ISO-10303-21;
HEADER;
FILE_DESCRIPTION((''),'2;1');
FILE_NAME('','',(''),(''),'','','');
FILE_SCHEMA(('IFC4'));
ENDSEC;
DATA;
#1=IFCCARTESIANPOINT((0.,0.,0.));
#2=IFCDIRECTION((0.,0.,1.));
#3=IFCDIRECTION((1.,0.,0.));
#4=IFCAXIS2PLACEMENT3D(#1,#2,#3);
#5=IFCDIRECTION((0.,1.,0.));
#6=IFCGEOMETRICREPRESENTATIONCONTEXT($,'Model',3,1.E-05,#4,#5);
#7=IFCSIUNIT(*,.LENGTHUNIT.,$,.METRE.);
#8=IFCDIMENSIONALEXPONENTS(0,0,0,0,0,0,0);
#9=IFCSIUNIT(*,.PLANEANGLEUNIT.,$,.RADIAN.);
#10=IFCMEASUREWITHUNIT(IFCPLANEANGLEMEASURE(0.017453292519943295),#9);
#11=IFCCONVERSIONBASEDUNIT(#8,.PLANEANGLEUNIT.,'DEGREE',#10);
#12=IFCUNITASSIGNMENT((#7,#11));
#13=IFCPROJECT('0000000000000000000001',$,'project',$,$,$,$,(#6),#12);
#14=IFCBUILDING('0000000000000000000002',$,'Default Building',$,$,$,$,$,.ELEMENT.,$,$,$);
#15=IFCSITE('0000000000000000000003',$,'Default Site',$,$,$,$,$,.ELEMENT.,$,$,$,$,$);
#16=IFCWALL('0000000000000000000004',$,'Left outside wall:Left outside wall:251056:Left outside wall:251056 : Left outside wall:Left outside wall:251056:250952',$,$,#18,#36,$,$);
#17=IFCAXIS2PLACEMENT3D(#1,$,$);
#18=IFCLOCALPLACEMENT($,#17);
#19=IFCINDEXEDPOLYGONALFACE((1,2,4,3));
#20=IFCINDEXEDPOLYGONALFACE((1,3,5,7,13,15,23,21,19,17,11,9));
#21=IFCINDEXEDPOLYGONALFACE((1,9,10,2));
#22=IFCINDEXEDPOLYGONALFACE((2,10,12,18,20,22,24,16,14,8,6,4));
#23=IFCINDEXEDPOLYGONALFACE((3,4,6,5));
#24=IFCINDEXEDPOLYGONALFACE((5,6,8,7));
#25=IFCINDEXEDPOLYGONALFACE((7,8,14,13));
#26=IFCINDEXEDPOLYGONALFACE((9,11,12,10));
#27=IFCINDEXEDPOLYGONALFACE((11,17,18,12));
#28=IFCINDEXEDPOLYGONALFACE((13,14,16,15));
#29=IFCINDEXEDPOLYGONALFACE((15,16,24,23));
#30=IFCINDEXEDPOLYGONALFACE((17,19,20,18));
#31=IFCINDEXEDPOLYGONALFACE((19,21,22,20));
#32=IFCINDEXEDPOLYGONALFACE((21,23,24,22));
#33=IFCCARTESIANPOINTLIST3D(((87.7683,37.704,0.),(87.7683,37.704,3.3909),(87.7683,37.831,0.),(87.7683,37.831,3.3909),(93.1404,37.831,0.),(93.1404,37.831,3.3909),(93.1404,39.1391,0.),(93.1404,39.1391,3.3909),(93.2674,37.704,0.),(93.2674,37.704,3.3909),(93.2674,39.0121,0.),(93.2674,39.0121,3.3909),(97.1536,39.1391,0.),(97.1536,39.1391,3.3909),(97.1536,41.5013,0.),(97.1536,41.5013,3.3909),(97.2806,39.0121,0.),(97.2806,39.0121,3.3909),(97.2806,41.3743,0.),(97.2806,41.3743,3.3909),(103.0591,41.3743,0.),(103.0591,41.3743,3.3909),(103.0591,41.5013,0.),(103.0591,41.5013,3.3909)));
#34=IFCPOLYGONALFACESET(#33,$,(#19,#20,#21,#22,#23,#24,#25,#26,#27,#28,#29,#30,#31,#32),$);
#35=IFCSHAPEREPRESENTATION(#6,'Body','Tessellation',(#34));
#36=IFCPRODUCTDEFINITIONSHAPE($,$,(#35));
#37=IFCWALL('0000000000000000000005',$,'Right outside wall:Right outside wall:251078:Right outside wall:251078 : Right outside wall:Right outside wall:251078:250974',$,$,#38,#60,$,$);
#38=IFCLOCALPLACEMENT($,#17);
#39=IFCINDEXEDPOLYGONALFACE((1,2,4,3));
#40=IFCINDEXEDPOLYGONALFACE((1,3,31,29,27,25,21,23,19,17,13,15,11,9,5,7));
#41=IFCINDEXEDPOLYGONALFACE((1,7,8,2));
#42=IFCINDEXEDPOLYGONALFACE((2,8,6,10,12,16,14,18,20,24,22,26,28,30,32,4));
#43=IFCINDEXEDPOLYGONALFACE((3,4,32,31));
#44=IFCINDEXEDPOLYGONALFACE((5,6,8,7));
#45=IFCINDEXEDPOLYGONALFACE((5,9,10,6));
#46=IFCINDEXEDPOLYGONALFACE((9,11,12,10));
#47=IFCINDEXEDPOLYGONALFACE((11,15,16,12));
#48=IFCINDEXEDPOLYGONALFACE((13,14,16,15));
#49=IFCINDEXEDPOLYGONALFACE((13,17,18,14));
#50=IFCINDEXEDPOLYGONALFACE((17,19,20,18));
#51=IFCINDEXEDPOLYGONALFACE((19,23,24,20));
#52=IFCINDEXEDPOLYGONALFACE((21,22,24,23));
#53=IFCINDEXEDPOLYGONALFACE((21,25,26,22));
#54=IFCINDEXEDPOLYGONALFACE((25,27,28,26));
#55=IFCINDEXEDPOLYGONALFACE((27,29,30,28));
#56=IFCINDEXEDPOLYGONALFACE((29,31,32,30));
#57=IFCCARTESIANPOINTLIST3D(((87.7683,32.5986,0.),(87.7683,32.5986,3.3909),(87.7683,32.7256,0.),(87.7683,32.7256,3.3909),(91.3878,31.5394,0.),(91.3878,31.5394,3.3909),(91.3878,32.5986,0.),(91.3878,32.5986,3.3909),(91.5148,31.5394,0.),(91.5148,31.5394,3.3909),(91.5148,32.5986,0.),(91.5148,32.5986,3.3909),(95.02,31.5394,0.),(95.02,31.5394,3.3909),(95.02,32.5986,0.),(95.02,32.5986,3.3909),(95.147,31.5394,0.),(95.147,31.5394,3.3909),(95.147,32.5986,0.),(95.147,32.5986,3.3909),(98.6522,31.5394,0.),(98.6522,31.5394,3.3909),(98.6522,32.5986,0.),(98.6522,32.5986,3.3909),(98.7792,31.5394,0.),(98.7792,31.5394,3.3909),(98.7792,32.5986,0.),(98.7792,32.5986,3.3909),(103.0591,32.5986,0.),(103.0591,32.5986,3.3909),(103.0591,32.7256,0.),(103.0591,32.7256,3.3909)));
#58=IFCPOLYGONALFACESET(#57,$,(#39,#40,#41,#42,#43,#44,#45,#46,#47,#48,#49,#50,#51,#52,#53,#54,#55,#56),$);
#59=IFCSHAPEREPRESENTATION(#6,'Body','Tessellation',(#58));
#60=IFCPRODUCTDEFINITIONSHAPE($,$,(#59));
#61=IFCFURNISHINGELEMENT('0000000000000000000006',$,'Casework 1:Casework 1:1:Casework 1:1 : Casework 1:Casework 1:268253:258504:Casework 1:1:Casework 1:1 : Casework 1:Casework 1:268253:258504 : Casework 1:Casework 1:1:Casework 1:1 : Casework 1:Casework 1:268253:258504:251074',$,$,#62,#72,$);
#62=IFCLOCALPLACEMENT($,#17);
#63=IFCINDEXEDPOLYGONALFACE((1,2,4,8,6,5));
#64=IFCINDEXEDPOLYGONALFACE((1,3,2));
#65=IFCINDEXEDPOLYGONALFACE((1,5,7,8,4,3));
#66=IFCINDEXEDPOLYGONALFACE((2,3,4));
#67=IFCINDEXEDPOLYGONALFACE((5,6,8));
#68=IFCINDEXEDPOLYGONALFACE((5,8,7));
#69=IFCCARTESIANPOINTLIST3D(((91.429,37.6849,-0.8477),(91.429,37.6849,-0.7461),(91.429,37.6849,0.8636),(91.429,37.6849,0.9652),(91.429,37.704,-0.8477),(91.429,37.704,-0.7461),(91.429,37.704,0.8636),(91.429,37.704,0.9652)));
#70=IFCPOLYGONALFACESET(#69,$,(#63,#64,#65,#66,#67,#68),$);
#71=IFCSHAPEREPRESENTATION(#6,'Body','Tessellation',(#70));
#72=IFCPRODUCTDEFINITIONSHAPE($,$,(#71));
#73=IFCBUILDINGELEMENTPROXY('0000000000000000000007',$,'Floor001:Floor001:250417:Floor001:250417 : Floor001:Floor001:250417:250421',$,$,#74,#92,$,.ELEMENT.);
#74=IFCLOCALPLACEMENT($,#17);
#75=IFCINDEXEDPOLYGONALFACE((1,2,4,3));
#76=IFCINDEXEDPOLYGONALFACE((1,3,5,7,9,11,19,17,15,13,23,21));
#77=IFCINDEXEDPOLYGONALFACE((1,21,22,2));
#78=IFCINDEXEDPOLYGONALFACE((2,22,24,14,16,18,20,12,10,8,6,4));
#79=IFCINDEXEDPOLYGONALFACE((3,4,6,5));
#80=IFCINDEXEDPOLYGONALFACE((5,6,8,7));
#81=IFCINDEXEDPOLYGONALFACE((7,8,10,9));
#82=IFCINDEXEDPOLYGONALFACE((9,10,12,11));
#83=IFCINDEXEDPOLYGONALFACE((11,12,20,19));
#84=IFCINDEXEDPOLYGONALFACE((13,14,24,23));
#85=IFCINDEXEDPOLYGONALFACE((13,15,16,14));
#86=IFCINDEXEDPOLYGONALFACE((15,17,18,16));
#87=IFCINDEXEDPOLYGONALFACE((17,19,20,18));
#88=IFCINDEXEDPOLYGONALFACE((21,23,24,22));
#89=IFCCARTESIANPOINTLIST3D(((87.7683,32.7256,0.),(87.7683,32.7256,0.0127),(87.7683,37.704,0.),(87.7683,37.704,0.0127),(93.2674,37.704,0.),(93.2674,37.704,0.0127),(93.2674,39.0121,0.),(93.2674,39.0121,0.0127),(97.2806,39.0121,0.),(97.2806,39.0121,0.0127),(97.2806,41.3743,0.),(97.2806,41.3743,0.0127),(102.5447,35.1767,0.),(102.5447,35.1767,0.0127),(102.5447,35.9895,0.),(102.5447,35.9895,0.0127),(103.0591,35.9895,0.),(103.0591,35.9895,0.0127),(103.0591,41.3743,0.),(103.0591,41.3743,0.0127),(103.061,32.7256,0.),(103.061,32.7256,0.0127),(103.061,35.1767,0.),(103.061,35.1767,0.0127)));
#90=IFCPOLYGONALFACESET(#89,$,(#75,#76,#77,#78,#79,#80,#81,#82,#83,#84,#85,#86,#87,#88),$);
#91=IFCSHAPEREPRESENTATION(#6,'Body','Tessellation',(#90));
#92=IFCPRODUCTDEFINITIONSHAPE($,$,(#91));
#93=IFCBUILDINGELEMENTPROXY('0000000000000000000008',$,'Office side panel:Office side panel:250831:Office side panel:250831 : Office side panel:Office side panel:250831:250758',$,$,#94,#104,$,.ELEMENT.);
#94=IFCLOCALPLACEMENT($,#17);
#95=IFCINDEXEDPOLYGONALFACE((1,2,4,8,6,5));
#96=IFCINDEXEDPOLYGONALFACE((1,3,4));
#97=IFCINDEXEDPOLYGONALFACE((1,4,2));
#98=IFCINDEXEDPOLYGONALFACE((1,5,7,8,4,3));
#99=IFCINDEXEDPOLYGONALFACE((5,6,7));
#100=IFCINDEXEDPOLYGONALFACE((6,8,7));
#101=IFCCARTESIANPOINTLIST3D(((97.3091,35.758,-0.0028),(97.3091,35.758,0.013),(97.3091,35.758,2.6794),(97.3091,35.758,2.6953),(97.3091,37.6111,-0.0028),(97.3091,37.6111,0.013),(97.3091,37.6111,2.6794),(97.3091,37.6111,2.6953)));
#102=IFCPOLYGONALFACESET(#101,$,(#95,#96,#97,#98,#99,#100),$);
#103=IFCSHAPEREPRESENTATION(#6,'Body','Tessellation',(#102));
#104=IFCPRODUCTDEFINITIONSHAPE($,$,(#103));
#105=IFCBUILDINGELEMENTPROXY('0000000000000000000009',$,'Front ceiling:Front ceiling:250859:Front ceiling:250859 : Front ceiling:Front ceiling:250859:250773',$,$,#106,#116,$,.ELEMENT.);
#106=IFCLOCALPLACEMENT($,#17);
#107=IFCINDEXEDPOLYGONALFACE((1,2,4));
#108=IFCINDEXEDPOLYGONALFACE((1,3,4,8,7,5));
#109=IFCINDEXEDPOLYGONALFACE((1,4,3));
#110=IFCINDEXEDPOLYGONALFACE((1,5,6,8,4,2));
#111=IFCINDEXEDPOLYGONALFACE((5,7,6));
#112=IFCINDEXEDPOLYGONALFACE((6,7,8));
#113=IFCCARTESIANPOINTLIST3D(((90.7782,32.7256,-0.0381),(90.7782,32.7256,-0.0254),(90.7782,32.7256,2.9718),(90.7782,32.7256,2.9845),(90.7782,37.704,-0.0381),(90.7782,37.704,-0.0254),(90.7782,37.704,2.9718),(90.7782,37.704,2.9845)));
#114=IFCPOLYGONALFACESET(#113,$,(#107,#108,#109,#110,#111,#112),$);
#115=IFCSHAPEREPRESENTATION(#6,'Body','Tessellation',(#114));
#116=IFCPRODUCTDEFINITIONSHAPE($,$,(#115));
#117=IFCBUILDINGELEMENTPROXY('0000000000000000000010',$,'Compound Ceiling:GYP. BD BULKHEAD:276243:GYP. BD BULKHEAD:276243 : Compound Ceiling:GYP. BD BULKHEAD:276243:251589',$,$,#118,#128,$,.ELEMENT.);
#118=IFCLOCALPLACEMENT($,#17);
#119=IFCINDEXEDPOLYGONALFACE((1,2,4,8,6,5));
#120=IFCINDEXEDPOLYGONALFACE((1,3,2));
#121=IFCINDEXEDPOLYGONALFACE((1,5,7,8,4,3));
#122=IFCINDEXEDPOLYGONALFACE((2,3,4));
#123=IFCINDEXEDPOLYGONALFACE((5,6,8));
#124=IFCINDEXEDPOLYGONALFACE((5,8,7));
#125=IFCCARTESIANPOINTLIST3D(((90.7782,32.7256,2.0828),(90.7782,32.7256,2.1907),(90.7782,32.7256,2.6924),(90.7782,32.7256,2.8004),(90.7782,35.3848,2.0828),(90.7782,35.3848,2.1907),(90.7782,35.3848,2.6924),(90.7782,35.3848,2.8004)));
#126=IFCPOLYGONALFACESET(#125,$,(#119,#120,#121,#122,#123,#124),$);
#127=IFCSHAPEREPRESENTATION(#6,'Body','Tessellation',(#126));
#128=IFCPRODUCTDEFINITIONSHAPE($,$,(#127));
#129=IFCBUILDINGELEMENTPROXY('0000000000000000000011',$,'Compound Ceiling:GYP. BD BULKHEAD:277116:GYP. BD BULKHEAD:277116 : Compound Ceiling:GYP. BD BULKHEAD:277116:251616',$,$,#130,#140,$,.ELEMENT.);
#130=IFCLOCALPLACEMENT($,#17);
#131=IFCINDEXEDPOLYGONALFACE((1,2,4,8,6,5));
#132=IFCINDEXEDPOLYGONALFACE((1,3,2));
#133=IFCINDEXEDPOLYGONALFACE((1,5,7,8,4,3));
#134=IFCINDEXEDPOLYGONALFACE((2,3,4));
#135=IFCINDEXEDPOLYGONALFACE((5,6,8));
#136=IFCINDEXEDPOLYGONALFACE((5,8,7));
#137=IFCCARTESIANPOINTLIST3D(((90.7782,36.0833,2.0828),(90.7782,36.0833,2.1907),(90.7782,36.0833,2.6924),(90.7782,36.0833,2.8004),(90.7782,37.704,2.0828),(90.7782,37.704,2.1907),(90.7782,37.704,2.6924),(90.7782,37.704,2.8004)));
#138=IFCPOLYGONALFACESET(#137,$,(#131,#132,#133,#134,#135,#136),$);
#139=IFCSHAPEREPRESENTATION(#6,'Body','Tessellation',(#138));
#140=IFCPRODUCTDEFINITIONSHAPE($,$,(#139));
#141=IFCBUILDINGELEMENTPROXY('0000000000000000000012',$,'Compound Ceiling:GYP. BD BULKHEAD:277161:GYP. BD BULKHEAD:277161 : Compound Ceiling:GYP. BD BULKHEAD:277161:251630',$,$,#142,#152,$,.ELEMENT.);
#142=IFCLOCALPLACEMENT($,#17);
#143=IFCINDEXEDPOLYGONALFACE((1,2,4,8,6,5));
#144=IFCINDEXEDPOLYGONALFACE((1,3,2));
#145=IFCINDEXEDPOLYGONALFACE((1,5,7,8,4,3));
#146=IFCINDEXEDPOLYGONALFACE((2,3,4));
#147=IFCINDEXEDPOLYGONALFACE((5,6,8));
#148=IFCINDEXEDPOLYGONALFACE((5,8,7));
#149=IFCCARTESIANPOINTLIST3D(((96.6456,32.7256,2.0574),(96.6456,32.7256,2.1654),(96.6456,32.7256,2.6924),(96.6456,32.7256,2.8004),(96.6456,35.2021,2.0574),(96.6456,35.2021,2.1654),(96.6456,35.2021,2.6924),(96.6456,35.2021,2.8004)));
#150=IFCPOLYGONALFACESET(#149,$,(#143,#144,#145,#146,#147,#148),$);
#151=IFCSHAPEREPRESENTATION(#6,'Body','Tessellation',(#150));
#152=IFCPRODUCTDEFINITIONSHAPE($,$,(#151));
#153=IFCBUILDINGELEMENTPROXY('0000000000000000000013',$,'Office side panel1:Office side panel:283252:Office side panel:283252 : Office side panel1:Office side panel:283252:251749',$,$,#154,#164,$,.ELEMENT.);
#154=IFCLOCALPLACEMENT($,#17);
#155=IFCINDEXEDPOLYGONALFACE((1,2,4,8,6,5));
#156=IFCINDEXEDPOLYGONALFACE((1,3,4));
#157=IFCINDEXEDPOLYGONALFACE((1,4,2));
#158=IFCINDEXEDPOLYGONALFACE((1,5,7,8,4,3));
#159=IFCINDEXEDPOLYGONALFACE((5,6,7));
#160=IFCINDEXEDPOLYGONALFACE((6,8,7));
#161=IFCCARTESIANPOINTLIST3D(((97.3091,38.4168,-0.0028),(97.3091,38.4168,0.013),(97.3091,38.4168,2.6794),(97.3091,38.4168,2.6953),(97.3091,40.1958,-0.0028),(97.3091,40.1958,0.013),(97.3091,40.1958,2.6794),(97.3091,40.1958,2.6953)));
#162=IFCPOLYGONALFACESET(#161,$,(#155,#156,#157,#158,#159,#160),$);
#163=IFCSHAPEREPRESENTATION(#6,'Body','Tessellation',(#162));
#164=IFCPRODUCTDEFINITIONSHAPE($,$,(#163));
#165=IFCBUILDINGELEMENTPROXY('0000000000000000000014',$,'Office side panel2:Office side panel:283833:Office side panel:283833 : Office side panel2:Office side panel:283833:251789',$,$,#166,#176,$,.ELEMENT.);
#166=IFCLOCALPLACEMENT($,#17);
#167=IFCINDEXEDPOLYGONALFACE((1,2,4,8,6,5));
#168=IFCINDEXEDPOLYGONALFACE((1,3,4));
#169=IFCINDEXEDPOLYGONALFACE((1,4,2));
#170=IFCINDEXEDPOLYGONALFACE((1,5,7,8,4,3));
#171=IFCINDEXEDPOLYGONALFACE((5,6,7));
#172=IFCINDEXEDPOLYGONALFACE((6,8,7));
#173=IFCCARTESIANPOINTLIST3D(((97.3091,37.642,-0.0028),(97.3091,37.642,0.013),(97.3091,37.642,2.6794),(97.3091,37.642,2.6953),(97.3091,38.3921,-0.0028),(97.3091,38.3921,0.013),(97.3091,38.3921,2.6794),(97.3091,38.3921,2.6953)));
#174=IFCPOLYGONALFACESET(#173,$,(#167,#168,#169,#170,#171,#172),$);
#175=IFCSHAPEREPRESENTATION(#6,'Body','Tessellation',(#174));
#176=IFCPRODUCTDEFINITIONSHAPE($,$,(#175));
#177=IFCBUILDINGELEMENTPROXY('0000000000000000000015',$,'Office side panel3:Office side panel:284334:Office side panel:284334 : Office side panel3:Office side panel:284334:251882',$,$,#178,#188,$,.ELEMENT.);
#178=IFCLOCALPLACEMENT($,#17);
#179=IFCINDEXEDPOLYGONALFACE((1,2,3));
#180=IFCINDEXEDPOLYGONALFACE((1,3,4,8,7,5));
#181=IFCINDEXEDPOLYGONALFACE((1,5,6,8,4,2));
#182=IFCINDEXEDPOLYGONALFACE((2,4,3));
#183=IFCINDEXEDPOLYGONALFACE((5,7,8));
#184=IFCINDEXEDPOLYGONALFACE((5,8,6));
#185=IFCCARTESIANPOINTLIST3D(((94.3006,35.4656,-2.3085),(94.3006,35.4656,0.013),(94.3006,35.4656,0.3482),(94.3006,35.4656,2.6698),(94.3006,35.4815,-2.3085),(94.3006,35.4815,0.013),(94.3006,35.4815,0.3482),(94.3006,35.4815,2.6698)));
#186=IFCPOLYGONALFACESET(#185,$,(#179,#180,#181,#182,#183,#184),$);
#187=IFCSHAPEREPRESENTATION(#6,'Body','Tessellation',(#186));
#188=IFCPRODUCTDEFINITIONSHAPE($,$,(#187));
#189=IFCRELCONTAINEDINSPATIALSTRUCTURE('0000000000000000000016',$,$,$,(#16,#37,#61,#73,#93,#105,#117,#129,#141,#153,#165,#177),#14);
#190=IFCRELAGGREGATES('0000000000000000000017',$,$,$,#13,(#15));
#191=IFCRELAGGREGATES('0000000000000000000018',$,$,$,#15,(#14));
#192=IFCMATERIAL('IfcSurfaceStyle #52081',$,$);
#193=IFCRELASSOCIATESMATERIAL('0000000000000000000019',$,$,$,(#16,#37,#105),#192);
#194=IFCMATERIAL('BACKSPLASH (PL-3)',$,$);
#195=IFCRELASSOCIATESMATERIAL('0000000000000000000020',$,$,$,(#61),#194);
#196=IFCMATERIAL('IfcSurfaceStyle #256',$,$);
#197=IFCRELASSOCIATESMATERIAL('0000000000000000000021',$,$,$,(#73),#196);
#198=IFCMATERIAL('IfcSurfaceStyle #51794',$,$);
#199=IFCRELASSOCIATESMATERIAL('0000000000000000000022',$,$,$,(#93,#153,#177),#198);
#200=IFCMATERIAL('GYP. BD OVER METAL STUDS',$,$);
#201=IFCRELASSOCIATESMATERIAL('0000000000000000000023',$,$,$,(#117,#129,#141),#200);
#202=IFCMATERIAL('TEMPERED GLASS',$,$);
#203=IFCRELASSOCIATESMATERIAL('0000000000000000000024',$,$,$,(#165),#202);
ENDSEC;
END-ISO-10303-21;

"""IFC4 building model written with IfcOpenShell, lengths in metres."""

from ifc_helpers import new_model, entity, si_unit, converted_unit, direction, frame, origin_with_axes, place, context, project, spatial, polyline, outline, extrude, material, element, save


model = new_model("IFC4")

# Units and contexts
model_context = context("Model", 3, precision=1e-05, world=origin_with_axes(), true_north=direction((0.0, 1.0, 0.0)))
ifc_project = project(units=[si_unit("LENGTHUNIT", "METRE"), converted_unit("PLANEANGLEUNIT", "DEGREE", entity("IfcPlaneAngleMeasure", 0.017453292519943295), si_unit("PLANEANGLEUNIT", "RADIAN"), dimensions=[0, 0, 0, 0, 0, 0, 0])], contexts=[model_context])

# Site, building
site = spatial("IfcSite", under=ifc_project, Name="Default Site", CompositionType="ELEMENT")
building = spatial("IfcBuilding", under=site, Name="Default Building", CompositionType="ELEMENT")

# Walls
ifc_material_1 = material(Name="IfcSurfaceStyle #52081")
wall_1_placement = place(None, origin_with_axes())
element("IfcWall", 1, at=wall_1_placement, inside=building, material=ifc_material_1, Name="Left outside wall:Left outside wall:251056:Left outside wall:251056 : Left outside wall:Left outside wall:251056:250952", context=model_context, shape_type="SweptSolid", body=[
    extrude(outline(polyline([(93.2674, 37.704), (87.7683, 37.704), (87.7683, 37.831), (93.1404, 37.831), (93.1404, 39.1391), (97.1536, 39.1391), (97.1536, 41.5013), (103.0591, 41.5013), (103.0591, 41.3743), (97.2806, 41.3743), (97.2806, 39.0121), (93.2674, 39.0121), (93.2674, 37.704)])), origin_with_axes(), (0.0, 0.0, 1.0), 3.3909),
])
wall_2_placement = place(None, origin_with_axes())
element("IfcWall", 2, at=wall_2_placement, inside=building, material=ifc_material_1, Name="Right outside wall:Right outside wall:251078:Right outside wall:251078 : Right outside wall:Right outside wall:251078:250974", context=model_context, shape_type="SweptSolid", body=[
    extrude(outline(polyline([(91.3878, 31.5394), (91.5148, 31.5394), (91.5148, 32.5986), (95.02, 32.5986), (95.02, 31.5394), (95.147, 31.5394), (95.147, 32.5986), (98.6522, 32.5986), (98.6522, 31.5394), (98.7792, 31.5394), (98.7792, 32.5986), (103.0591, 32.5986), (103.0591, 32.7256), (87.7683, 32.7256), (87.7683, 32.5986), (91.3878, 32.5986), (91.3878, 31.5394)])), origin_with_axes(), (0.0, 0.0, 1.0), 3.3909),
])

# Furnishing element
ifc_material_2 = material(Name="BACKSPLASH (PL-3)")
furnishing_1_placement = place(None, origin_with_axes())
element("IfcFurnishingElement", 3, at=furnishing_1_placement, inside=building, material=ifc_material_2, Name="Casework 1:Casework 1:1:Casework 1:1 : Casework 1:Casework 1:268253:258504:Casework 1:1:Casework 1:1 : Casework 1:Casework 1:268253:258504 : Casework 1:Casework 1:1:Casework 1:1 : Casework 1:Casework 1:268253:258504:251074", context=model_context, shape_type="SweptSolid", body=[
    extrude(outline(polyline([(0.0508, 0.0095), (-0.0508, 0.0095), (-0.0508, -0.0095), (0.0508, -0.0095), (0.0508, 0.0095)])), frame((91.429, 37.6944, 0.9144), z_axis=(1.0, 0.0, 0.0), x_axis=(0.0, 0.0, -1.0)), (1.0, 0.0, 0.0), 1.7113),
])

# Building element proxies
ifc_material_3 = material(Name="IfcSurfaceStyle #256")
proxy_1_placement = place(None, origin_with_axes())
element("IfcBuildingElementProxy", 4, at=proxy_1_placement, inside=building, material=ifc_material_3, Name="Floor001:Floor001:250417:Floor001:250417 : Floor001:Floor001:250417:250421", PredefinedType="ELEMENT", context=model_context, shape_type="SweptSolid", body=[
    extrude(outline(polyline([(87.7683, 32.7256), (103.061, 32.7256), (103.061, 35.1767), (102.5447, 35.1767), (102.5447, 35.9895), (103.0591, 35.9895), (103.0591, 41.3743), (97.2806, 41.3743), (97.2806, 39.0121), (93.2674, 39.0121), (93.2674, 37.704), (87.7683, 37.704), (87.7683, 32.7256)])), origin_with_axes(), (0.0, 0.0, 1.0), 0.0127),
])
ifc_material_4 = material(Name="IfcSurfaceStyle #51794")
proxy_2_placement = place(None, origin_with_axes())
element("IfcBuildingElementProxy", 5, at=proxy_2_placement, inside=building, material=ifc_material_4, Name="Office side panel:Office side panel:250831:Office side panel:250831 : Office side panel:Office side panel:250831:250758", PredefinedType="ELEMENT", context=model_context, shape_type="SweptSolid", body=[
    extrude(outline(polyline([(-1.3411, -0.9265), (1.3411, -0.9265), (1.3411, 0.9265), (-1.3411, 0.9265), (-1.3411, -0.9265)])), frame((97.3091, 36.6846, 1.3542), z_axis=(-1.0, 0.0, 0.0), x_axis=(0.0, 0.0, 1.0)), (-1.0, 0.0, 0.0), 0.0159),
])
proxy_3_placement = place(None, origin_with_axes())
element("IfcBuildingElementProxy", 6, at=proxy_3_placement, inside=building, material=ifc_material_1, Name="Front ceiling:Front ceiling:250859:Front ceiling:250859 : Front ceiling:Front ceiling:250859:250773", PredefinedType="ELEMENT", context=model_context, shape_type="SweptSolid", body=[
    extrude(outline(polyline([(-0.0063, -2.4892), (0.0063, -2.4892), (0.0063, 2.4892), (-0.0063, 2.4892), (-0.0063, -2.4892)])), frame((90.7782, 35.2148, 2.9781), z_axis=(-1.0, 0.0, 0.0), x_axis=(0.0, 0.0, 1.0)), (-1.0, 0.0, 0.0), 3.0099),
])
ifc_material_5 = material(Name="GYP. BD OVER METAL STUDS")
proxy_4_placement = place(None, origin_with_axes())
element("IfcBuildingElementProxy", 7, at=proxy_4_placement, inside=building, material=ifc_material_5, Name="Compound Ceiling:GYP. BD BULKHEAD:276243:GYP. BD BULKHEAD:276243 : Compound Ceiling:GYP. BD BULKHEAD:276243:251589", PredefinedType="ELEMENT", context=model_context, shape_type="SweptSolid", body=[
    extrude(outline(polyline([(0.054, 1.3296), (-0.054, 1.3296), (-0.054, -1.3296), (0.054, -1.3296), (0.054, 1.3296)])), frame((90.7782, 34.0552, 2.7464), z_axis=(1.0, 0.0, 0.0), x_axis=(0.0, 0.0, -1.0)), (1.0, 0.0, 0.0), 0.6096),
])
proxy_5_placement = place(None, origin_with_axes())
element("IfcBuildingElementProxy", 8, at=proxy_5_placement, inside=building, material=ifc_material_5, Name="Compound Ceiling:GYP. BD BULKHEAD:277116:GYP. BD BULKHEAD:277116 : Compound Ceiling:GYP. BD BULKHEAD:277116:251616", PredefinedType="ELEMENT", context=model_context, shape_type="SweptSolid", body=[
    extrude(outline(polyline([(0.054, 0.8103), (-0.054, 0.8103), (-0.054, -0.8103), (0.054, -0.8103), (0.054, 0.8103)])), frame((90.7782, 36.8936, 2.7464), z_axis=(1.0, 0.0, 0.0), x_axis=(0.0, 0.0, -1.0)), (1.0, 0.0, 0.0), 0.6096),
])
proxy_6_placement = place(None, origin_with_axes())
element("IfcBuildingElementProxy", 9, at=proxy_6_placement, inside=building, material=ifc_material_5, Name="Compound Ceiling:GYP. BD BULKHEAD:277161:GYP. BD BULKHEAD:277161 : Compound Ceiling:GYP. BD BULKHEAD:277161:251630", PredefinedType="ELEMENT", context=model_context, shape_type="SweptSolid", body=[
    extrude(outline(polyline([(0.054, 1.2383), (-0.054, 1.2383), (-0.054, -1.2383), (0.054, -1.2383), (0.054, 1.2383)])), frame((96.6456, 33.9638, 2.7464), z_axis=(1.0, 0.0, 0.0), x_axis=(0.0, 0.0, -1.0)), (1.0, 0.0, 0.0), 0.635),
])
proxy_7_placement = place(None, origin_with_axes())
element("IfcBuildingElementProxy", 10, at=proxy_7_placement, inside=building, material=ifc_material_4, Name="Office side panel1:Office side panel:283252:Office side panel:283252 : Office side panel1:Office side panel:283252:251749", PredefinedType="ELEMENT", context=model_context, shape_type="SweptSolid", body=[
    extrude(outline(polyline([(-1.3411, -0.8895), (1.3411, -0.8895), (1.3411, 0.8895), (-1.3411, 0.8895), (-1.3411, -0.8895)])), frame((97.3091, 39.3063, 1.3542), z_axis=(-1.0, 0.0, 0.0), x_axis=(0.0, 0.0, 1.0)), (-1.0, 0.0, 0.0), 0.0159),
])
ifc_material_6 = material(Name="TEMPERED GLASS")
proxy_8_placement = place(None, origin_with_axes())
element("IfcBuildingElementProxy", 11, at=proxy_8_placement, inside=building, material=ifc_material_6, Name="Office side panel2:Office side panel:283833:Office side panel:283833 : Office side panel2:Office side panel:283833:251789", PredefinedType="ELEMENT", context=model_context, shape_type="SweptSolid", body=[
    extrude(outline(polyline([(-1.3411, -0.3751), (1.3411, -0.3751), (1.3411, 0.3751), (-1.3411, 0.3751), (-1.3411, -0.3751)])), frame((97.3091, 38.0171, 1.3542), z_axis=(-1.0, 0.0, 0.0), x_axis=(0.0, 0.0, 1.0)), (-1.0, 0.0, 0.0), 0.0159),
])
proxy_9_placement = place(None, origin_with_axes())
element("IfcBuildingElementProxy", 12, at=proxy_9_placement, inside=building, material=ifc_material_4, Name="Office side panel3:Office side panel:284334:Office side panel:284334 : Office side panel3:Office side panel:284334:251882", PredefinedType="ELEMENT", context=model_context, shape_type="SweptSolid", body=[
    extrude(outline(polyline([(1.3284, 0.0079), (-1.3284, 0.0079), (-1.3284, -0.0079), (1.3284, -0.0079), (1.3284, 0.0079)])), frame((94.3006, 35.4735, 1.3414), z_axis=(1.0, 0.0, 0.0), x_axis=(0.0, 0.0, -1.0)), (1.0, 0.0, 0.0), 2.3216),
])

save(model, "model.ifc")
